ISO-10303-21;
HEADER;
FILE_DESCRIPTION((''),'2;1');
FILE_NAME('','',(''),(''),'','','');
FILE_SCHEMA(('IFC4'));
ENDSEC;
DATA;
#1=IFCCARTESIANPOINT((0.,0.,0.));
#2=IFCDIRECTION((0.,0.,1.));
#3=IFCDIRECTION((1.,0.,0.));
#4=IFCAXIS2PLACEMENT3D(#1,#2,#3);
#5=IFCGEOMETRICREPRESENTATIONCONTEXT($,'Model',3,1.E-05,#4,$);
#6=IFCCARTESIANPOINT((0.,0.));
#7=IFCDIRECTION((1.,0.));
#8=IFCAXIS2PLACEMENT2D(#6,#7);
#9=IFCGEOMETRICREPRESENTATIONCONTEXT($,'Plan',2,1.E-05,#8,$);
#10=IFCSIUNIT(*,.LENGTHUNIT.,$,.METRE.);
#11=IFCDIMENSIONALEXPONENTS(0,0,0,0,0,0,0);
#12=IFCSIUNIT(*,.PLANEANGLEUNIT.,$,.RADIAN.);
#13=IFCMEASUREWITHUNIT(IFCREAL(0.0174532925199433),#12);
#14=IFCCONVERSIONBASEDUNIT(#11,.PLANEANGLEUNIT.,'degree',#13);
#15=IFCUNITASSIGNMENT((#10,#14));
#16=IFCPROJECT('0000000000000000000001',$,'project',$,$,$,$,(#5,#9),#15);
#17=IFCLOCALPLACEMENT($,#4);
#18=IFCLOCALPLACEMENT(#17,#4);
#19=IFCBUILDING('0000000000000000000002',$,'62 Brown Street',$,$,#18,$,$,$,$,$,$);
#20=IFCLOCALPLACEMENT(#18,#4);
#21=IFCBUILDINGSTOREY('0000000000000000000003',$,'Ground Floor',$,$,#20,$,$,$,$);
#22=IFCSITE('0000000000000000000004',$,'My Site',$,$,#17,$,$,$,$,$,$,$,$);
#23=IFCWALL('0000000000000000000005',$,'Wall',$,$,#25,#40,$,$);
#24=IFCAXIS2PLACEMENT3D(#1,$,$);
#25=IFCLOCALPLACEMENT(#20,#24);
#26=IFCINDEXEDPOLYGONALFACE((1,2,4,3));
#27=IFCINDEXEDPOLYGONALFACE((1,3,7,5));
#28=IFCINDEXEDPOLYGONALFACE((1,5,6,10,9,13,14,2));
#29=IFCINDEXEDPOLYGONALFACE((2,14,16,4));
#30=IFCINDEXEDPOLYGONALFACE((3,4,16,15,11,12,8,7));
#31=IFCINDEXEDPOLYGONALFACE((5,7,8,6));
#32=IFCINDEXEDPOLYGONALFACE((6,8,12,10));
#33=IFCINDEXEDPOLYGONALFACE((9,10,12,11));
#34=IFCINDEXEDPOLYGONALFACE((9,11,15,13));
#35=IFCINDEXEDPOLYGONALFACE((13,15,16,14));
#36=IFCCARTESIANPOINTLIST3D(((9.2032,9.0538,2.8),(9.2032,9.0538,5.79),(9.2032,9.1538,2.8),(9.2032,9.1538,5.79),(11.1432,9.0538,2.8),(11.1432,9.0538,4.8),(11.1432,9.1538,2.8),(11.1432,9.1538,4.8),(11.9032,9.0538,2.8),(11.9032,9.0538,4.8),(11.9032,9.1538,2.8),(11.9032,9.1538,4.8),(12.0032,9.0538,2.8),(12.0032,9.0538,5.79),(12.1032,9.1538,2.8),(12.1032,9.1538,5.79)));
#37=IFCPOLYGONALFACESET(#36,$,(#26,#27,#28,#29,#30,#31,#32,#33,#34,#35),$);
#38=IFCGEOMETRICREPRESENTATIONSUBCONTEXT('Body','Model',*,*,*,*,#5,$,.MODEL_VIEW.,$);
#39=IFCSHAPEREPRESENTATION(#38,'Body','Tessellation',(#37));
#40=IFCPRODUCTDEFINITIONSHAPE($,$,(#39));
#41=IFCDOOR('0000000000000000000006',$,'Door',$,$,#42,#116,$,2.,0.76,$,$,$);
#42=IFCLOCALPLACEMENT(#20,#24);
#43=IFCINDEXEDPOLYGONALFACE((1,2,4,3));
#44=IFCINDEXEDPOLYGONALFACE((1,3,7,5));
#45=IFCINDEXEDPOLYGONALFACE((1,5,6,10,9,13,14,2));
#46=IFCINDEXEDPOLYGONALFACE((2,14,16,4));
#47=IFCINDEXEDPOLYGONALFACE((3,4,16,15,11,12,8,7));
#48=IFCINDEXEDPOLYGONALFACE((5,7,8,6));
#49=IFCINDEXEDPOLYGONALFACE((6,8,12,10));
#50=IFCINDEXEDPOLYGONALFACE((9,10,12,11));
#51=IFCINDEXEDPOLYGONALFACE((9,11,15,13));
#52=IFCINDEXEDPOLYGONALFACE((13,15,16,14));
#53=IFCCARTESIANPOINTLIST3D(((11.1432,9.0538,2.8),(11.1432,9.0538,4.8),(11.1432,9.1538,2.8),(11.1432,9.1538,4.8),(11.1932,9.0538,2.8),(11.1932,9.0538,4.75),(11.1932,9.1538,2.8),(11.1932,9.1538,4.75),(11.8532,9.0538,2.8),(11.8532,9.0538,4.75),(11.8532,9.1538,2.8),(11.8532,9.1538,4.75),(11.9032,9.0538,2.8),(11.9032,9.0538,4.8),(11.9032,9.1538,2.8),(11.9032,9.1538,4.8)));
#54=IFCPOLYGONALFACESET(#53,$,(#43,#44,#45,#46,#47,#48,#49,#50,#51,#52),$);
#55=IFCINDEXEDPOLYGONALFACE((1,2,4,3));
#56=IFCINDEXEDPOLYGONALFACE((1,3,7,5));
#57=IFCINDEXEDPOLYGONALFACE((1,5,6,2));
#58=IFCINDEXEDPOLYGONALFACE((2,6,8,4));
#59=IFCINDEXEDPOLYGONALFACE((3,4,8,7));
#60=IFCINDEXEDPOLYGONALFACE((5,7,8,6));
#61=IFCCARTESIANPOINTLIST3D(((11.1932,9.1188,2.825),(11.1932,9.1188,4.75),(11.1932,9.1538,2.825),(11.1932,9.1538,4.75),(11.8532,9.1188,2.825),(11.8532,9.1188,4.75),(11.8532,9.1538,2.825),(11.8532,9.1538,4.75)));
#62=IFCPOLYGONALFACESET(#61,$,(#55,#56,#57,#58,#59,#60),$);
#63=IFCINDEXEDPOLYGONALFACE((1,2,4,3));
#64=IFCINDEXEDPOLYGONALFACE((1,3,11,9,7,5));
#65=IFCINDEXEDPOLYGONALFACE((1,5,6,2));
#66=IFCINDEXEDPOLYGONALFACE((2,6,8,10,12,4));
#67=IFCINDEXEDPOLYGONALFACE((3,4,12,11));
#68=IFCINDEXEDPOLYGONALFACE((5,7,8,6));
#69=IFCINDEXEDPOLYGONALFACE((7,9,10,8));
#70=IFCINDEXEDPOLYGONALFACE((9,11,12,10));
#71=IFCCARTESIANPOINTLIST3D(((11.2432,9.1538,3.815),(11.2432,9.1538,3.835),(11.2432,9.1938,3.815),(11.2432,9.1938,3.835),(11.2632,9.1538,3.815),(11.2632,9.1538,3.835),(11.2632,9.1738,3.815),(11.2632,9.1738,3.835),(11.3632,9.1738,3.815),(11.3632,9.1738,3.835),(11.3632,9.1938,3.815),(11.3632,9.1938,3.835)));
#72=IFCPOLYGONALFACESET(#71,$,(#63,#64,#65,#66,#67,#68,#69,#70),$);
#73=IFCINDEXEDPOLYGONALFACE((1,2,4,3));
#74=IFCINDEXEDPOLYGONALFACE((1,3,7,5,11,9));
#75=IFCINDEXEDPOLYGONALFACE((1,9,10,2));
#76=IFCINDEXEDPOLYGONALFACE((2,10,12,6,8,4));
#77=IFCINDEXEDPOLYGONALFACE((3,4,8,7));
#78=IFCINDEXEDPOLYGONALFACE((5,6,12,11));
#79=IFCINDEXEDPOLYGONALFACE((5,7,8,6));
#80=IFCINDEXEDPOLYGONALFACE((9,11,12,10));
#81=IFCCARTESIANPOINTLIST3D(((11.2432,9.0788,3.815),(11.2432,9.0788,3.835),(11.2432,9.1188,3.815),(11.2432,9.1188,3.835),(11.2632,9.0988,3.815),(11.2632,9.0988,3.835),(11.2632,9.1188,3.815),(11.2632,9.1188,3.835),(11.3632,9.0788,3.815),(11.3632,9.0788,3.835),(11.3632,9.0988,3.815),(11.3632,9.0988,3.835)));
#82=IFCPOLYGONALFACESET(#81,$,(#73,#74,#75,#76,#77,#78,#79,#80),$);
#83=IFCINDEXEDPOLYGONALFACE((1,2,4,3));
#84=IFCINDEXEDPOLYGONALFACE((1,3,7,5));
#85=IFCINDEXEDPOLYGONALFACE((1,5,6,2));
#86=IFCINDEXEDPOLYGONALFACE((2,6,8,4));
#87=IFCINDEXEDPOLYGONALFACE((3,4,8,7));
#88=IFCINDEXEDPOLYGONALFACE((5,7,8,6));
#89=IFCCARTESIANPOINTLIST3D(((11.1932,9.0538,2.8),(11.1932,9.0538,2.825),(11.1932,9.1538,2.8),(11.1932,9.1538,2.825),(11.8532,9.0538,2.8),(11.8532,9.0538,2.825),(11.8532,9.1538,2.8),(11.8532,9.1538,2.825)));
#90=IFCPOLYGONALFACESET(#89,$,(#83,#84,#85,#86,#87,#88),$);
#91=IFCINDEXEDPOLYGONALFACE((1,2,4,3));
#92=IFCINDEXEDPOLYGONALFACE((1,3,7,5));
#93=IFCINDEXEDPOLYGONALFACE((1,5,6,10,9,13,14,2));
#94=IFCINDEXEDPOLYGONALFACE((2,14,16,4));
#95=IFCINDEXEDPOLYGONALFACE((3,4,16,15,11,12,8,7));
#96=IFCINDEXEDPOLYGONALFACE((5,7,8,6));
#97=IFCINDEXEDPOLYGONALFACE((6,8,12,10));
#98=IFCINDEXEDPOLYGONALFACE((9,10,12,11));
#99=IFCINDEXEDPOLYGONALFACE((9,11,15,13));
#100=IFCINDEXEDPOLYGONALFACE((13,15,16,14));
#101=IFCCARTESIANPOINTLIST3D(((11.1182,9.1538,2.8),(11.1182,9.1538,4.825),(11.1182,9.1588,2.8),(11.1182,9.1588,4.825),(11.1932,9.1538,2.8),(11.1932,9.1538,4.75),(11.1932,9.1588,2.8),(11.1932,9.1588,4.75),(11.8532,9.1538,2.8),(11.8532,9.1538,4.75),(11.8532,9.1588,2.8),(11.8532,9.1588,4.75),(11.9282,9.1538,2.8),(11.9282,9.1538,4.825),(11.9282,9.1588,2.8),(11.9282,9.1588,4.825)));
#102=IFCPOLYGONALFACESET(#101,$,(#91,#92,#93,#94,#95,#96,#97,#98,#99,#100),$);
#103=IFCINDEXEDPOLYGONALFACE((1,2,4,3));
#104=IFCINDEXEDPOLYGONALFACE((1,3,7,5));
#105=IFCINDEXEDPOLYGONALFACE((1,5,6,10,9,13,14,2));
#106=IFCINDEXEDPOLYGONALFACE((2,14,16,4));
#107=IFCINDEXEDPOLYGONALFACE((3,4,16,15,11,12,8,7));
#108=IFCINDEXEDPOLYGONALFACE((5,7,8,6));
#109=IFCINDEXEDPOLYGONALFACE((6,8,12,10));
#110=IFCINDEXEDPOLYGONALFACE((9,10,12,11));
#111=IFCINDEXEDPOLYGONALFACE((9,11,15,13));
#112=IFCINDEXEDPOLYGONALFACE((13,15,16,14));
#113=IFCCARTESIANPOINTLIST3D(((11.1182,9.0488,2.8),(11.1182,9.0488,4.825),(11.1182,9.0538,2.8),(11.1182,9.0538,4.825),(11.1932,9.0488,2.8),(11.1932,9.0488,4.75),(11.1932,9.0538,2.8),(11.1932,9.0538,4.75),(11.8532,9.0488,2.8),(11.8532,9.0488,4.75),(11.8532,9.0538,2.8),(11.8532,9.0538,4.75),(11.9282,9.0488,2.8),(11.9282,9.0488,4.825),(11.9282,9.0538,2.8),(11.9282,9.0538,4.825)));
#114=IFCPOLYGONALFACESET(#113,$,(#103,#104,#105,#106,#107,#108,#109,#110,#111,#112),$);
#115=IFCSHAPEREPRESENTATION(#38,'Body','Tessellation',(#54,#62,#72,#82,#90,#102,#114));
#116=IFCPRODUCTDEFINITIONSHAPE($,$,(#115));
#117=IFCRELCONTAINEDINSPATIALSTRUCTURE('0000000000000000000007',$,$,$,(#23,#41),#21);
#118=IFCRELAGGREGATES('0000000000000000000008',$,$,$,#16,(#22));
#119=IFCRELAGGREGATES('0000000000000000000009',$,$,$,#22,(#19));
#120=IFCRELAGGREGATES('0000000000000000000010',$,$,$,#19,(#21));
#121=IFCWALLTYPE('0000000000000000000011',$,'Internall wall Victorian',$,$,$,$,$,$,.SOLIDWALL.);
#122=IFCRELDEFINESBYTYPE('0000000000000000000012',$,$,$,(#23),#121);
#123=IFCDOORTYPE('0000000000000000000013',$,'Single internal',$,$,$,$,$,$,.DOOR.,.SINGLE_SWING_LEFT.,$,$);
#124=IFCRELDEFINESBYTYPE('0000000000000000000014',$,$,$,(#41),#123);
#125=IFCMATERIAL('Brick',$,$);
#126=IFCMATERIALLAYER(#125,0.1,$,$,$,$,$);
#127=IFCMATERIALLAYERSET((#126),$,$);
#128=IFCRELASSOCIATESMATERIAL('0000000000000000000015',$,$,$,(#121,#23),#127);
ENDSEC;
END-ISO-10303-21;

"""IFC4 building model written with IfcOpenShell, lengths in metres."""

from ifc_helpers import new_model, entity, si_unit, converted_unit, frame, origin_with_axes, origin_2d_with_axis, place, context, subcontext, project, spatial, line, indexed_curve, outline, extrude, clip, halfspace, shape, source, transform, mapped, material, layer, layer_set, layer_usage, type_object, type_shapes, element, fill, save


model = new_model("IFC4")

# Units and contexts
model_context = context("Model", 3, precision=1e-05, world=origin_with_axes())
plan_context = context("Plan", 2, precision=1e-05, world=origin_2d_with_axis())
body_context_1 = subcontext(model_context, "Body", "Model", "MODEL_VIEW")
body_context_2 = subcontext(plan_context, "Body", "Plan", "PLAN_VIEW")
ifc_project = project(units=[si_unit("LENGTHUNIT", "METRE"), converted_unit("PLANEANGLEUNIT", "degree", entity("IfcReal", 0.0174532925199433), si_unit("PLANEANGLEUNIT", "RADIAN"), dimensions=[0, 0, 0, 0, 0, 0, 0])], contexts=[model_context, plan_context])

# Site, building, storey
site_placement = place(None, origin_with_axes())
site = spatial("IfcSite", under=ifc_project, at=site_placement, Name="My Site")
building_placement = place(site_placement, origin_with_axes())
building = spatial("IfcBuilding", under=site, at=building_placement, Name="62 Brown Street")
storey_placement = place(building_placement, origin_with_axes())
storey = spatial("IfcBuildingStorey", under=building, at=storey_placement, Name="Ground Floor")

# Shared definitions
ifc_material_1 = material(Name="Brick")

# Shared definitions
ifc_layer_1 = layer(ifc_material_1, 0.1)
ifc_layer_set_1 = layer_set([ifc_layer_1])
wall_type_1 = type_object("IfcWallType", Name="Internall wall Victorian", PredefinedType="SOLIDWALL", material=ifc_layer_set_1)

# Wall, opening, door
ifc_layer_usage_1 = layer_usage(ifc_layer_set_1, "AXIS2", "POSITIVE", 0.0)
wall_1_placement = place(storey_placement, frame((12.1032, 9.1538, 2.8), z_axis=(0.0, 0.0, 1.0), x_axis=(-1.0, 0.0, 0.0)))
wall_1 = element("IfcWall", 1, at=wall_1_placement, inside=storey, type_object=wall_type_1, material=ifc_layer_usage_1, Name="Wall", context=body_context_1, shape_type="Clipping", body=[
    clip(extrude(outline(indexed_curve([(0.0, 0.0), (0.0, 0.1), (2.9, 0.1), (2.9, 0.0), (0.0, 0.0)], self_intersect=False)), origin_with_axes(), (0.0, 0.0, 1.0), 2.99), halfspace(frame((0.0, 0.0, -2.8), z_axis=(-0.299001, 0.299001, 0.0), x_axis=(0.1, 0.1, 0.0)), False)),
])
shared_shape_1 = source(origin_with_axes(), body_context_1, "Body", "SweptSolid", [
    extrude(outline(indexed_curve([(0.0, 0.0), (0.76, 0.0), (0.76, 2.0), (0.0, 2.0)], segments=[line(1, 2, 3, 4, 1)])), frame((0.0, -0.6, 0.0), z_axis=(0.0, -1.0, 0.0), x_axis=(1.0, 0.0, 0.0)), (0.0, 0.0, -1.0), 1.2),
])
opening_1_placement = place(wall_1_placement, frame((0.2, 0.0, 0.0), z_axis=(0.0, 0.0, 1.0), x_axis=(1.0, 0.0, 0.0)))
opening_1 = element("IfcOpeningElement", 2, at=opening_1_placement, cuts=wall_1, PredefinedType="OPENING", context=body_context_1, shape_type="MappedRepresentation", body=[
    mapped(shared_shape_1, transform((0.0, 0.0, 0.0), x_axis=(1.0, 0.0, 0.0), y_axis=(0.0, 1.0, 0.0), z_axis=(0.0, 0.0, 1.0), scale=1.0)),
])
door_type_1 = type_object("IfcDoorType", Name="Single internal", OperationType="SINGLE_SWING_LEFT", PredefinedType="DOOR")
shared_shape_2 = source(origin_with_axes(), body_context_1, "Body", "SweptSolid", [
    extrude(outline(indexed_curve([(0.0, 0.0), (0.0, 2.0), (0.76, 2.0), (0.76, 0.0), (0.71, 0.0), (0.71, 1.95), (0.05, 1.95), (0.05, 0.0)], segments=[line(1, 2, 3, 4, 5, 6, 7, 8, 1)])), frame((0.0, 0.0, 0.0), z_axis=(0.0, -1.0, 0.0), x_axis=(1.0, 0.0, 0.0)), (0.0, 0.0, -1.0), 0.1),
    extrude(outline(indexed_curve([(0.0, 0.0), (0.66, 0.0), (0.66, 0.035), (0.0, 0.035)], segments=[line(1, 2, 3, 4, 1)])), frame((0.05, 0.0, 0.025), z_axis=(0.0, 0.0, 1.0), x_axis=(1.0, 0.0, 0.0)), (0.0, 0.0, 1.0), 1.925),
    extrude(outline(indexed_curve([(0.0, 0.0), (0.0, -0.04), (-0.12, -0.04), (-0.12, -0.02), (-0.02, -0.02), (-0.02, 0.0)], segments=[line(1, 2, 3, 4, 5, 6, 1)])), frame((0.66, 0.0, 1.015), z_axis=(0.0, 0.0, 1.0), x_axis=(1.0, 0.0, 0.0)), (0.0, 0.0, 1.0), 0.02),
    extrude(outline(indexed_curve([(0.0, 0.0), (0.0, 0.04), (-0.12, 0.04), (-0.12, 0.02), (-0.02, 0.02), (-0.02, 0.0)], segments=[line(1, 2, 3, 4, 5, 6, 1)])), frame((0.66, 0.035, 1.015), z_axis=(0.0, 0.0, 1.0), x_axis=(1.0, 0.0, 0.0)), (0.0, 0.0, 1.0), 0.02),
    extrude(outline(indexed_curve([(0.0, 0.0), (0.66, 0.0), (0.66, 0.1), (0.0, 0.1)], segments=[line(1, 2, 3, 4, 1)])), frame((0.05, 0.0, 0.0), z_axis=(0.0, 0.0, 1.0), x_axis=(1.0, 0.0, 0.0)), (0.0, 0.0, 1.0), 0.025),
    extrude(outline(indexed_curve([(0.0, 0.0), (0.0, 2.025), (0.81, 2.025), (0.81, 0.0), (0.735, 0.0), (0.735, 1.95), (0.075, 1.95), (0.075, 0.0)], segments=[line(1, 2, 3, 4, 5, 6, 7, 8, 1)])), frame((-0.025, -0.005, 0.0), z_axis=(0.0, -1.0, 0.0), x_axis=(1.0, 0.0, 0.0)), (0.0, 0.0, -1.0), 0.005),
    extrude(outline(indexed_curve([(0.0, 0.0), (0.0, 2.025), (0.81, 2.025), (0.81, 0.0), (0.735, 0.0), (0.735, 1.95), (0.075, 1.95), (0.075, 0.0)], segments=[line(1, 2, 3, 4, 5, 6, 7, 8, 1)])), frame((-0.025, 0.1, 0.0), z_axis=(0.0, -1.0, 0.0), x_axis=(1.0, 0.0, 0.0)), (0.0, 0.0, -1.0), 0.005),
])
shared_shape_3 = source(origin_with_axes(), body_context_2, "Body", "Curve2D", [
    entity("IfcIndexedPolyCurve", entity("IfcCartesianPointList2D", [[0.0, 0.0], [0.05, 0.0], [0.05, 0.1], [0.0, 0.1]]), [entity("IfcLineIndex", [1, 2, 3, 4, 1])]),
    entity("IfcIndexedPolyCurve", entity("IfcCartesianPointList2D", [[0.76, 0.0], [0.71, 0.0], [0.71, 0.1], [0.76, 0.1]]), [entity("IfcLineIndex", [1, 2, 3, 4, 1])]),
    entity("IfcTrimmedCurve", entity("IfcEllipse", entity("IfcAxis2Placement2D", entity("IfcCartesianPoint", [0.085, 0.1]), entity("IfcDirection", [1.0, 0.0])), 0.625, 0.66), [entity("IfcCartesianPoint", [0.71, 0.1])], [entity("IfcCartesianPoint", [0.085, 0.76])], True, "CARTESIAN"),
    entity("IfcIndexedPolyCurve", entity("IfcCartesianPointList2D", [[0.05, 0.1], [0.085, 0.1], [0.085, 0.76], [0.05, 0.76]]), [entity("IfcLineIndex", [1, 2, 3, 4, 1])]),
])
type_shapes(door_type_1, [shared_shape_2, shared_shape_3])
door_1_placement = place(opening_1_placement, origin_with_axes())
door_1 = element("IfcDoor", 3, at=door_1_placement, inside=storey, type_object=door_type_1, Name="Door", OverallHeight=2.0, OverallWidth=0.76, shapes=[
    shape(body_context_1, "Body", "MappedRepresentation", [mapped(shared_shape_2, transform((0.0, 0.0, 0.0), x_axis=(1.0, 0.0, 0.0), y_axis=(0.0, 1.0, 0.0), z_axis=(0.0, 0.0, 1.0), scale=1.0))]),
    shape(body_context_2, "Body", "MappedRepresentation", [mapped(shared_shape_3, transform((0.0, 0.0, 0.0), x_axis=(1.0, 0.0, 0.0), y_axis=(0.0, 1.0, 0.0), z_axis=(0.0, 0.0, 1.0), scale=1.0))]),
])
fill(opening_1, door_1)

save(model, "model.ifc")
